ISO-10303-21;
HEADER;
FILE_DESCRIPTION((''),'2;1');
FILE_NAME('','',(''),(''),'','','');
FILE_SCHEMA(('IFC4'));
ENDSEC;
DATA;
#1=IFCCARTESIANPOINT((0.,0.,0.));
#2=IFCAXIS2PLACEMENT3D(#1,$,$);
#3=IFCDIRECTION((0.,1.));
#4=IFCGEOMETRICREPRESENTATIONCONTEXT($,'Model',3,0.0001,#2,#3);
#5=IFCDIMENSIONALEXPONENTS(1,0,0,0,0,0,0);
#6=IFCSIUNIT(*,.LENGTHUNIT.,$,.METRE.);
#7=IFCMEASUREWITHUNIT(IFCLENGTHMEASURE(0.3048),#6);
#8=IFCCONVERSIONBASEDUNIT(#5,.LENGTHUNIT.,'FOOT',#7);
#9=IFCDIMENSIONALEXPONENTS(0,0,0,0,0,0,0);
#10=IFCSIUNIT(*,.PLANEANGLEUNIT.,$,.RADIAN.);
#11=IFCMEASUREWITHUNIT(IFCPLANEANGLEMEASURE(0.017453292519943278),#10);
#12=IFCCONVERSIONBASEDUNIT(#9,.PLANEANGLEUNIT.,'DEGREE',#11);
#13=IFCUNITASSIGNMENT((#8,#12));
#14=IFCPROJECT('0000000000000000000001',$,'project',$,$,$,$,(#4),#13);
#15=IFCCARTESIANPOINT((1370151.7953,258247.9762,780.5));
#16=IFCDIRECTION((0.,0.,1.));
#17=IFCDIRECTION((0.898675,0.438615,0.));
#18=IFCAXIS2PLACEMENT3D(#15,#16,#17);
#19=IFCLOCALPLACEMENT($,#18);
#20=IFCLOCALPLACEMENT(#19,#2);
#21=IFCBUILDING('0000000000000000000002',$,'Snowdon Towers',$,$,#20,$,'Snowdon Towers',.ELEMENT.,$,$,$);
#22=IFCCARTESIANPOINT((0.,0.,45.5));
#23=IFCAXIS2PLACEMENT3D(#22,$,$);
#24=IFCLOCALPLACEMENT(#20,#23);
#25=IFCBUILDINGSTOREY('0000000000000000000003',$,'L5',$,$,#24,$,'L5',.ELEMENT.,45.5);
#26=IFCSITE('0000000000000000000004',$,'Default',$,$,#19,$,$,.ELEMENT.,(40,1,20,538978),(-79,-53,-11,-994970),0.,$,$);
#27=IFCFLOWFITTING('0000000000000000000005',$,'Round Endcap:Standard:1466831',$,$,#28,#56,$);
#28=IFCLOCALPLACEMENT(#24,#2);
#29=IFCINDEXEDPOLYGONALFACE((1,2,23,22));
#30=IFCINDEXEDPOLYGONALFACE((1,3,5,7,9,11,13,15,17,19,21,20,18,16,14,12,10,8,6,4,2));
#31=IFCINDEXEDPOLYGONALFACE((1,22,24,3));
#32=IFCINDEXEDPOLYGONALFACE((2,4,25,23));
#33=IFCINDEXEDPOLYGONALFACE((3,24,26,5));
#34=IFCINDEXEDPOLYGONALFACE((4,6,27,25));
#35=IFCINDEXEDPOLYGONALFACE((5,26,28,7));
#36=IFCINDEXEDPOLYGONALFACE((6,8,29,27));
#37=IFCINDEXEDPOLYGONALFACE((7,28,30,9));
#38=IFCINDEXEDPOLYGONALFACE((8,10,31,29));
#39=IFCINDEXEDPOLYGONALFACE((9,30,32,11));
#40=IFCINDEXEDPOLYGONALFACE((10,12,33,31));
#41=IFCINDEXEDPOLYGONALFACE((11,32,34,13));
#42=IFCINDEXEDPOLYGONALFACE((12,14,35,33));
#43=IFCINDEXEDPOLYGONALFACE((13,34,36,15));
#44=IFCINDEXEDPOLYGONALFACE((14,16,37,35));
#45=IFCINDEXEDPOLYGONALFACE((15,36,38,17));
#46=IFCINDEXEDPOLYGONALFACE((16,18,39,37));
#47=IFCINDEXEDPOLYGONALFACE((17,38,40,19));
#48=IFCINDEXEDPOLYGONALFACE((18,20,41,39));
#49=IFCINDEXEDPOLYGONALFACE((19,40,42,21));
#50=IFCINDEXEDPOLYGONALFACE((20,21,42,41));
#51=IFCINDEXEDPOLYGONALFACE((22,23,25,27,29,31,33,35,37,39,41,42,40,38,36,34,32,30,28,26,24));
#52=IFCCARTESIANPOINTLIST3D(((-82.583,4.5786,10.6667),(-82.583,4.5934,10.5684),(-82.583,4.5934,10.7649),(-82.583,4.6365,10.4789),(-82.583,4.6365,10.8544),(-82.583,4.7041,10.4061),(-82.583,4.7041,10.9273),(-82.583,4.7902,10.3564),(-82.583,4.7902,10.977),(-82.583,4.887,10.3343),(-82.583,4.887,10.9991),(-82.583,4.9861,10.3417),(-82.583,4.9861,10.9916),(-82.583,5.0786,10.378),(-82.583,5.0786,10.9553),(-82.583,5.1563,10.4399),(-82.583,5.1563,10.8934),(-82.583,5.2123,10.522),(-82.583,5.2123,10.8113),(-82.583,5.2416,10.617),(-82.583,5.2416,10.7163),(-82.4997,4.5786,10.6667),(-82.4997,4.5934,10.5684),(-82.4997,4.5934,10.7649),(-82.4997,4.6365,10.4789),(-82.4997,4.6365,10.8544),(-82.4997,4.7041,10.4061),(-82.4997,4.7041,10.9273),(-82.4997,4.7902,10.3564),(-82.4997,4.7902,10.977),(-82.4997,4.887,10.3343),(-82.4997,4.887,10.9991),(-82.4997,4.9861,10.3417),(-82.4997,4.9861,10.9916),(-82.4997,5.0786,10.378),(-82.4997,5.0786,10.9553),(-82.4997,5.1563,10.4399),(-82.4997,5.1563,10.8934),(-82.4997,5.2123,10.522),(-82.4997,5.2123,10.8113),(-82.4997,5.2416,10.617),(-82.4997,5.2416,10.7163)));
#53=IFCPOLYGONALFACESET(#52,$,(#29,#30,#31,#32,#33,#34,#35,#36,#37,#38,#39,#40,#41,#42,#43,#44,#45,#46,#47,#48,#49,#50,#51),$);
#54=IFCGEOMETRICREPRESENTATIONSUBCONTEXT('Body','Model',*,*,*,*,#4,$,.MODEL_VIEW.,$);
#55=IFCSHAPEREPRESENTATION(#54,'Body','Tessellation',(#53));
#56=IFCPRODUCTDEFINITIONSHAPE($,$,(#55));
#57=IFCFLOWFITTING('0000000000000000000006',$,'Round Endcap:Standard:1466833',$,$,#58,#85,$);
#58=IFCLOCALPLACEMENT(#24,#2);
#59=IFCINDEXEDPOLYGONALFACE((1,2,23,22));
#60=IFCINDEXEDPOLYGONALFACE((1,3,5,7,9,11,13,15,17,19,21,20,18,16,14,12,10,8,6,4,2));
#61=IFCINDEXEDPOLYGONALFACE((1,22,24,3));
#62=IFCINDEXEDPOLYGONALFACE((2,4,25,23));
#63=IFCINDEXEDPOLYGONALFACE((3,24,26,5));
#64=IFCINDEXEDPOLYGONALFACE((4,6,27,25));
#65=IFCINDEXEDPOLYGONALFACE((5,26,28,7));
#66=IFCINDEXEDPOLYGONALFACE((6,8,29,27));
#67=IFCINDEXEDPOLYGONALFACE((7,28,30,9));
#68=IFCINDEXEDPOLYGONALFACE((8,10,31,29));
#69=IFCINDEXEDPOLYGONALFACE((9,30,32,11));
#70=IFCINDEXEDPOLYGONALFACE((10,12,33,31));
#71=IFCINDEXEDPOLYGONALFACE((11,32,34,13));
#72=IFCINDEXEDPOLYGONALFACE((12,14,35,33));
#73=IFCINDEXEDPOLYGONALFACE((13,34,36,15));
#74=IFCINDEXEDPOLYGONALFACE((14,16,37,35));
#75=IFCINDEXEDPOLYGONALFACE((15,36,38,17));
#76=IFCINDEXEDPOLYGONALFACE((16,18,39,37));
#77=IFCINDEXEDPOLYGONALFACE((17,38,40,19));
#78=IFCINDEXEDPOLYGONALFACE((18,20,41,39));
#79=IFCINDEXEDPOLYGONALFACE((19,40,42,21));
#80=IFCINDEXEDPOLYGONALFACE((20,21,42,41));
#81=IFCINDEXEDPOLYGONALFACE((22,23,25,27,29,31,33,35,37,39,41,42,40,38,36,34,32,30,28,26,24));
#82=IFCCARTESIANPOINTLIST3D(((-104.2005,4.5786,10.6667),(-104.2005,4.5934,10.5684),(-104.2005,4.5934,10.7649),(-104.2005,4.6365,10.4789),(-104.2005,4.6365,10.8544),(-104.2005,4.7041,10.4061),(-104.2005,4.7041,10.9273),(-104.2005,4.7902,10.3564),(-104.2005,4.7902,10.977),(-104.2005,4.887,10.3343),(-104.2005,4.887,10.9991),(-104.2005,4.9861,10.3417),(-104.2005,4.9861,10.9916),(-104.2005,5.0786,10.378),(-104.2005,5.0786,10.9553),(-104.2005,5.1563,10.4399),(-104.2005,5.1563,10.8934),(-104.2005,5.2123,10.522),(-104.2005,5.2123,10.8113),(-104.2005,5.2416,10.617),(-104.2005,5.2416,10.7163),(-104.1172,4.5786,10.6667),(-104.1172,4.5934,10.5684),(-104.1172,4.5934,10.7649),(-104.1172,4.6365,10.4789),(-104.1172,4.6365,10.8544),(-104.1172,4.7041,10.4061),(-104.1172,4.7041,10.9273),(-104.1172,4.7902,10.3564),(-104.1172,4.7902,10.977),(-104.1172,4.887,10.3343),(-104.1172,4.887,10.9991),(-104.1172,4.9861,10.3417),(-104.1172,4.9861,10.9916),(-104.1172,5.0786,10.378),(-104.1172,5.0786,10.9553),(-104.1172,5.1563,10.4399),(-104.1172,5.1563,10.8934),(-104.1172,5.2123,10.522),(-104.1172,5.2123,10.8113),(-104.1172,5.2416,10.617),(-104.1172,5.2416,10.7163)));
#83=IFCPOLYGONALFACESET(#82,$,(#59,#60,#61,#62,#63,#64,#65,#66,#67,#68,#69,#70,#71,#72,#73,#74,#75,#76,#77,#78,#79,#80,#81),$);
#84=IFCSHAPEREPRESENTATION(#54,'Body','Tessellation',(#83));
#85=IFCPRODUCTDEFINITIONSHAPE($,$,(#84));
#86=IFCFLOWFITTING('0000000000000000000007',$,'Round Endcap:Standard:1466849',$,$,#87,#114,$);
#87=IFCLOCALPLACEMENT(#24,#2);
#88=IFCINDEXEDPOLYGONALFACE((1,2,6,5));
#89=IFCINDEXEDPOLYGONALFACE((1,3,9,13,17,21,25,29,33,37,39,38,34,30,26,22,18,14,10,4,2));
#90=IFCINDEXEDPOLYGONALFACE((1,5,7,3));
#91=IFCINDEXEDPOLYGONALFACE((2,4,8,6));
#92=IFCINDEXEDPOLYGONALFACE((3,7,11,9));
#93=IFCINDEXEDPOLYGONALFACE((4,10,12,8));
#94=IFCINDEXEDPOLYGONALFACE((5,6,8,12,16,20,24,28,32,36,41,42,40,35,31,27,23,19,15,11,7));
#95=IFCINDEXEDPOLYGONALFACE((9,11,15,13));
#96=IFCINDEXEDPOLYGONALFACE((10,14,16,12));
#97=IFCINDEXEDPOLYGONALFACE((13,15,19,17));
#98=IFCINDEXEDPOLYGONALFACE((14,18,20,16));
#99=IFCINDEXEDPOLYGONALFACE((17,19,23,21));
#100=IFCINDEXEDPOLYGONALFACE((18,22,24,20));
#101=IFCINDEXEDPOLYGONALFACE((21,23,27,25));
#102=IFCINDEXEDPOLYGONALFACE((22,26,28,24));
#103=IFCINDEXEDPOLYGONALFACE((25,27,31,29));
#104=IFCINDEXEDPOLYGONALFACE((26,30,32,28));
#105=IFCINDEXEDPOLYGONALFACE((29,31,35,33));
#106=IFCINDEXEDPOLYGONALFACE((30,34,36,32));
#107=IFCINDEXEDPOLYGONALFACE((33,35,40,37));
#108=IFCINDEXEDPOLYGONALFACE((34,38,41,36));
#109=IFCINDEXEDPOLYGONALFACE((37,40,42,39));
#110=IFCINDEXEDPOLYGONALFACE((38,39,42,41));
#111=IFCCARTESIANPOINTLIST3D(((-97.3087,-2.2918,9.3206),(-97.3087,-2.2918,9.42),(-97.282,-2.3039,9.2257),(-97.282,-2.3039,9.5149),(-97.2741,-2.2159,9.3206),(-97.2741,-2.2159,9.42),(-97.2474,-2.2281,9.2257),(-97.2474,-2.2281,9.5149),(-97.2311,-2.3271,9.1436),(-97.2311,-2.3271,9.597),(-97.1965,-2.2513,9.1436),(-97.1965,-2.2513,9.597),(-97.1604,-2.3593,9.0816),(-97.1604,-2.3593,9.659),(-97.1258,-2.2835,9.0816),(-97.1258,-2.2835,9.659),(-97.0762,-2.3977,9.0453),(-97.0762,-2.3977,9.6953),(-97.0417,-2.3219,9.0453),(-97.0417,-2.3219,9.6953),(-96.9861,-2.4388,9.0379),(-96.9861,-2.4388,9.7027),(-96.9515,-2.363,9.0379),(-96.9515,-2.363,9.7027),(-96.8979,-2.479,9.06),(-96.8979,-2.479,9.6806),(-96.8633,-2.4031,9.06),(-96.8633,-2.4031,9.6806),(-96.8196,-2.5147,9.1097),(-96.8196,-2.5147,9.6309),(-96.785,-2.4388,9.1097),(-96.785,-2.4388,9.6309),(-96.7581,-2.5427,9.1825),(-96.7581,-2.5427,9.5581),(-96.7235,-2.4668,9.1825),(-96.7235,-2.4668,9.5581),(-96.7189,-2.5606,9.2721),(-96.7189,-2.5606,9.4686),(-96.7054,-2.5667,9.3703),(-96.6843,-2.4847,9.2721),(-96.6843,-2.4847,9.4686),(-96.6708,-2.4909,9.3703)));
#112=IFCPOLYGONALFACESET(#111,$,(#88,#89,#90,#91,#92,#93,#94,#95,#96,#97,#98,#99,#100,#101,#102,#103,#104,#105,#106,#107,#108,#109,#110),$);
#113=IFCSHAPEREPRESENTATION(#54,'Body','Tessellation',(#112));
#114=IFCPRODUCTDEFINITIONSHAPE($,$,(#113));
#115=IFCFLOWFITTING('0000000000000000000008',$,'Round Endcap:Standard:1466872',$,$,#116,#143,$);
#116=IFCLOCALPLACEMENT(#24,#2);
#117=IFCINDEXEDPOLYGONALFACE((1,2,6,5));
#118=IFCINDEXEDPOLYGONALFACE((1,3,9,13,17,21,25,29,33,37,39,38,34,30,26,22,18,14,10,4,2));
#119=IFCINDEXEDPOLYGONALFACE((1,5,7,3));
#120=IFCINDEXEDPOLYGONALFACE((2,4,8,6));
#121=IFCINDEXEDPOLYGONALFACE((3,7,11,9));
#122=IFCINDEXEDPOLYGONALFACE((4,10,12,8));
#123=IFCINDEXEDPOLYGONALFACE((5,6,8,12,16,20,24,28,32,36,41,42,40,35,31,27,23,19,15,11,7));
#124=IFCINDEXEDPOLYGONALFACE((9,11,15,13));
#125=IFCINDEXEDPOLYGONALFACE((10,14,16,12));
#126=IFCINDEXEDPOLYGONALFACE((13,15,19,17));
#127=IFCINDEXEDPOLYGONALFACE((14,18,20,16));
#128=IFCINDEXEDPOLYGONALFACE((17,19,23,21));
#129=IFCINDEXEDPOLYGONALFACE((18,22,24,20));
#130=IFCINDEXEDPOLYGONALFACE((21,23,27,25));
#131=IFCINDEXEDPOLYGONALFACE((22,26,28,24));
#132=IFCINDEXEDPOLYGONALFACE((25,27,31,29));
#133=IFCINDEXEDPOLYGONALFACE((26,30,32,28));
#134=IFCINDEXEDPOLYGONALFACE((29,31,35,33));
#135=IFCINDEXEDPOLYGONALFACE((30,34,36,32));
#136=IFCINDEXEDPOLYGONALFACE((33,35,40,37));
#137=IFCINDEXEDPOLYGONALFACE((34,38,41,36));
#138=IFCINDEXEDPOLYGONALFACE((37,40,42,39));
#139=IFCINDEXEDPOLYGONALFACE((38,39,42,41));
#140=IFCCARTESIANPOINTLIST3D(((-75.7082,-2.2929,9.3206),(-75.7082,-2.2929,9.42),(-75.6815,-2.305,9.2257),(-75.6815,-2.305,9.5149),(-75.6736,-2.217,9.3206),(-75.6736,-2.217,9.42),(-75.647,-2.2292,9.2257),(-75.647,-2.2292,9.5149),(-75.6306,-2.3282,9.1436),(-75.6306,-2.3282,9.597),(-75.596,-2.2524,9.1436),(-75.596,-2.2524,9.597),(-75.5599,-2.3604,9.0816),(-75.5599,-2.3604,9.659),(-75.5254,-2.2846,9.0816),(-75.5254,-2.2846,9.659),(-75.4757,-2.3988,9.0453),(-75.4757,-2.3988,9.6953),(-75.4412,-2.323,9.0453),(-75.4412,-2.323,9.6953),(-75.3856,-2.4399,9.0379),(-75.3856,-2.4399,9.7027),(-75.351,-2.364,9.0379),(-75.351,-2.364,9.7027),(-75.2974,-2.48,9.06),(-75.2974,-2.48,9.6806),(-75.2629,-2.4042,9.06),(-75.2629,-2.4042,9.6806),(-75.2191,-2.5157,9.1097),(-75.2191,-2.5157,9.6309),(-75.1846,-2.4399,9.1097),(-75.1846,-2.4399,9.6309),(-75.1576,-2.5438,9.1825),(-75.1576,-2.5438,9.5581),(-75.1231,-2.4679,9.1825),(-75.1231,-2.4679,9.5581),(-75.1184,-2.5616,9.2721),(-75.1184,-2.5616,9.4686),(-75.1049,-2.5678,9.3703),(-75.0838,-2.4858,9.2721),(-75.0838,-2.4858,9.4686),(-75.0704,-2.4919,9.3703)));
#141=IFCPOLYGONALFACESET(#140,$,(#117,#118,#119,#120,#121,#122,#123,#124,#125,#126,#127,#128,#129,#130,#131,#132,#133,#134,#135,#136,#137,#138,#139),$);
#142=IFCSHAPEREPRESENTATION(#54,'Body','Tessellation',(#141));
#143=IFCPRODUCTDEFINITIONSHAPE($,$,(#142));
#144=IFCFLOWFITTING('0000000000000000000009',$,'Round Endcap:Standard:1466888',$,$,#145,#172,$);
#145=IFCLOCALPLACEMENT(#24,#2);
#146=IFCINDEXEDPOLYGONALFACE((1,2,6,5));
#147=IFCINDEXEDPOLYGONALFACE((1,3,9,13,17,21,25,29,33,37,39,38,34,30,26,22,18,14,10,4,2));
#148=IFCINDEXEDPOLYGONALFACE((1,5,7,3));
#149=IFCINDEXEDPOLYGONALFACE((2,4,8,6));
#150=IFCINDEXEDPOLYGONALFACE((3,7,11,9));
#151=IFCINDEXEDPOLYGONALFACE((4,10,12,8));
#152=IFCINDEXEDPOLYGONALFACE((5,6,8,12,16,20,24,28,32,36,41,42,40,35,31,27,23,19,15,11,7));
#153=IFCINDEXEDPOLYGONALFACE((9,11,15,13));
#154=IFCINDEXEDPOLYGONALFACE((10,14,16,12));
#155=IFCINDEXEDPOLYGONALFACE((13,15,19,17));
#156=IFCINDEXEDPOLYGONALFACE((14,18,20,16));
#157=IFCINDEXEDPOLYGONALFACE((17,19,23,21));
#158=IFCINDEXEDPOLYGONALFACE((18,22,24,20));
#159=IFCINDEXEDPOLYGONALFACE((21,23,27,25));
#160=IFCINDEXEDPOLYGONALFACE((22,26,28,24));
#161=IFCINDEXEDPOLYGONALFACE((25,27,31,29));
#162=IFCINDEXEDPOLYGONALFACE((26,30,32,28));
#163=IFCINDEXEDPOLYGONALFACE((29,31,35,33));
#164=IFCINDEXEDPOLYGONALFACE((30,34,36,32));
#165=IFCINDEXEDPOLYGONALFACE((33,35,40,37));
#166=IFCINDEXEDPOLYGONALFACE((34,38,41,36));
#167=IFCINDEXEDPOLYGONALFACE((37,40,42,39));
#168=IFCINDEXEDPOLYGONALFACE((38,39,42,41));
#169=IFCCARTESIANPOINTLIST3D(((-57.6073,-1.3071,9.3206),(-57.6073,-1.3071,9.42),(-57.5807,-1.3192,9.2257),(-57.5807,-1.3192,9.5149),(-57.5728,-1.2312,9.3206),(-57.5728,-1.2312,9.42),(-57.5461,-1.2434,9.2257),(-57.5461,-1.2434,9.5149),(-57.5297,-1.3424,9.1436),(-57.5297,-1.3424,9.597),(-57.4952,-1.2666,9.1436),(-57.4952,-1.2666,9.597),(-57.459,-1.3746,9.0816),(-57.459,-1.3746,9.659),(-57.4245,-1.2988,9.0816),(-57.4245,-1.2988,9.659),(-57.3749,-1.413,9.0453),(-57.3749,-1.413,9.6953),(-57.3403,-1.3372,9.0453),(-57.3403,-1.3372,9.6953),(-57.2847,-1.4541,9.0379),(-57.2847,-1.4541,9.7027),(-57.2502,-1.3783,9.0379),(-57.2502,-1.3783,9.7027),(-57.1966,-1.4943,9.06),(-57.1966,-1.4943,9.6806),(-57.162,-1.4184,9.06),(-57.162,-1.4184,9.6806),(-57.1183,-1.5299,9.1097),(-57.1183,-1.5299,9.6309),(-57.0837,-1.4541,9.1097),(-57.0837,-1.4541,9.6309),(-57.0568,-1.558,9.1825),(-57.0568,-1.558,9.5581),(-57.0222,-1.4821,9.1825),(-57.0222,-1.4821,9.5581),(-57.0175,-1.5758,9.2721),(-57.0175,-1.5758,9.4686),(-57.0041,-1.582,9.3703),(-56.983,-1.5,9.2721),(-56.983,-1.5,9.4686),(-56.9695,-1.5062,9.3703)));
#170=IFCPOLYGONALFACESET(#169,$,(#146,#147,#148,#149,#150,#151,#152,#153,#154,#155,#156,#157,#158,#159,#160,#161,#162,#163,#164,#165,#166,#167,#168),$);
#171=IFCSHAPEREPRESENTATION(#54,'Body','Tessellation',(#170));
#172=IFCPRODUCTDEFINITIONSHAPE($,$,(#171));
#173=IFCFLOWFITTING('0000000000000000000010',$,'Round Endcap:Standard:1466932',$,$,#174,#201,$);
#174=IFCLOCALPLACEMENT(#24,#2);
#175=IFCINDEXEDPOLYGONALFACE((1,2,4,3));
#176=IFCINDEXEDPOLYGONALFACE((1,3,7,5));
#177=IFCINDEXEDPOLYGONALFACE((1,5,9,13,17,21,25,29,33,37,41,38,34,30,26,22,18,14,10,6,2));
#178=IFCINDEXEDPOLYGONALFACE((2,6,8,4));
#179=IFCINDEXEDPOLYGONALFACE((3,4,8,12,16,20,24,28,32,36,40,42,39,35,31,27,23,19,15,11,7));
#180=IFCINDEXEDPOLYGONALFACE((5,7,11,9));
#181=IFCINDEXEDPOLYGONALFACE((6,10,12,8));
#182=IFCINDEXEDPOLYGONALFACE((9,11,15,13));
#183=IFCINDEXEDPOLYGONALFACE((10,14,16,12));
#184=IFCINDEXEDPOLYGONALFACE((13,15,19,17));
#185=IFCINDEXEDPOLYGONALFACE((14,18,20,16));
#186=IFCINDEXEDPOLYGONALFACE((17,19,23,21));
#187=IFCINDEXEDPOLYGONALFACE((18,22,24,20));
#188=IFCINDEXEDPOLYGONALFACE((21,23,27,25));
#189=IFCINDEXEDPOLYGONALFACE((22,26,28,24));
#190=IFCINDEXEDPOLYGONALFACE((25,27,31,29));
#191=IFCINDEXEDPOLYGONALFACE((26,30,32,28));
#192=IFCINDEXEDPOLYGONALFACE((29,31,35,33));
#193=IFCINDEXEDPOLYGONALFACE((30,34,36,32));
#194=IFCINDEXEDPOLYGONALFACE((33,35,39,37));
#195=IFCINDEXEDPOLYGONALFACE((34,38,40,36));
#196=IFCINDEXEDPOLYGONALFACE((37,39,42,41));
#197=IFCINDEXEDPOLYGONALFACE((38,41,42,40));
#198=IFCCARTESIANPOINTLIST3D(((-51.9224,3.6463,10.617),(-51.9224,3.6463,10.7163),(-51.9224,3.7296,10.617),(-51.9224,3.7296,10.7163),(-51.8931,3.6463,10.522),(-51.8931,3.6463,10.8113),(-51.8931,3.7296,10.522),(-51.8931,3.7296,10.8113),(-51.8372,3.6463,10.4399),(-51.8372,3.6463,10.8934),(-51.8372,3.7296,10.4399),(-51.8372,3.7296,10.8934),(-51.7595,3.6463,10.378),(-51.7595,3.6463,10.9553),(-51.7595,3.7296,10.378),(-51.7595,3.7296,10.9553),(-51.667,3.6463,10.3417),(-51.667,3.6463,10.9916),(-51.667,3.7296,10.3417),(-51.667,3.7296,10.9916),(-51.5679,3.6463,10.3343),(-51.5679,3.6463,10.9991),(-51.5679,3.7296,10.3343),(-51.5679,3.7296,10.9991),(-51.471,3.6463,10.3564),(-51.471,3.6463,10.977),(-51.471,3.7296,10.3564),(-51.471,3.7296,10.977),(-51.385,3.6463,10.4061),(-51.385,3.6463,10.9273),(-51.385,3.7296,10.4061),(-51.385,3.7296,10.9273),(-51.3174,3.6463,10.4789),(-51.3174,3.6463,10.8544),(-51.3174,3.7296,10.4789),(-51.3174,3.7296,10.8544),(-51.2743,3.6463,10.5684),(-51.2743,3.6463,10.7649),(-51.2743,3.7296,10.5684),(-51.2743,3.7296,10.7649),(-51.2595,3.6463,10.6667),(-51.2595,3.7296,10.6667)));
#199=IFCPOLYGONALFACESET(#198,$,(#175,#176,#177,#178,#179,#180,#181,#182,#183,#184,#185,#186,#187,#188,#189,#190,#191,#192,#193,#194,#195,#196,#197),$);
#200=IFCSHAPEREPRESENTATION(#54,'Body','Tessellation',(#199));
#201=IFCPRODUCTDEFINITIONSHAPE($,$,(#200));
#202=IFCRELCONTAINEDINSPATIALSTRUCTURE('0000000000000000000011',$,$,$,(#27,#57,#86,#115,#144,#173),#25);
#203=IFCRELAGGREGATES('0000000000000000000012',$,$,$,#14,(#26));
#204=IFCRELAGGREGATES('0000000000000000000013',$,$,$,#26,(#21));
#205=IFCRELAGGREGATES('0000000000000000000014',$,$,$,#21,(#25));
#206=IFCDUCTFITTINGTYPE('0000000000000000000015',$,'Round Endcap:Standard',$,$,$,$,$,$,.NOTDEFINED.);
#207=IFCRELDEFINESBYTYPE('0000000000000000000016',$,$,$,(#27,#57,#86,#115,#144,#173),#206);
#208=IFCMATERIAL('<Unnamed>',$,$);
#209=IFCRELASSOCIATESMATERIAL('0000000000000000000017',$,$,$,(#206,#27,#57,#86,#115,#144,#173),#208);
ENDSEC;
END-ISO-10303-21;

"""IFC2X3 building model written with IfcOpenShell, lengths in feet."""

from ifc_helpers import new_model, entity, si_unit, converted_unit, direction, frame, frame_2d, origin, place, context, subcontext, project, spatial, circle, extrude, source, transform, mapped, material, type_object, type_shapes, element, save


model = new_model("IFC2X3")

# Units and contexts
model_context = context("Model", 3, precision=0.0001, world=origin(), true_north=direction((0.0, 1.0)))
body_context = subcontext(model_context, "Body", "Model", "MODEL_VIEW")
ifc_project = project(units=[converted_unit("LENGTHUNIT", "FOOT", entity("IfcLengthMeasure", 0.3048), si_unit("LENGTHUNIT", "METRE"), dimensions=[1, 0, 0, 0, 0, 0, 0]), converted_unit("PLANEANGLEUNIT", "DEGREE", entity("IfcPlaneAngleMeasure", 0.017453292519943278), si_unit("PLANEANGLEUNIT", "RADIAN"), dimensions=[0, 0, 0, 0, 0, 0, 0])], contexts=[model_context])

# Site, building, storey
site_placement = place(None, frame((1370151.7953, 258247.9762, 780.5), z_axis=(0.0, 0.0, 1.0), x_axis=(0.898675, 0.438615, 0.0)))
site = spatial("IfcSite", under=ifc_project, at=site_placement, Name="Default", CompositionType="ELEMENT", RefLatitude=(40, 1, 20, 538978), RefLongitude=(-79, -53, -11, -994970), RefElevation=0.0)
building_placement = place(site_placement, origin())
building = spatial("IfcBuilding", under=site, at=building_placement, Name="Snowdon Towers", LongName="Snowdon Towers", CompositionType="ELEMENT")
storey_placement = place(building_placement, frame((0.0, 0.0, 45.5)))
storey = spatial("IfcBuildingStorey", under=building, at=storey_placement, Name="L5", LongName="L5", CompositionType="ELEMENT", Elevation=45.5)

# Flow fittings
ifc_material = material(Name="<Unnamed>")
duct_fitting_type = type_object("IfcDuctFittingType", Name="Round Endcap:Standard", PredefinedType="NOTDEFINED", material=ifc_material)
shared_shape_1 = source(origin(), body_context, "Body", "SweptSolid", [
    extrude(circle(Radius=0.3333, at=frame_2d((0.0, 0.0), x_axis=(1.0, 0.0))), frame((0.0, 0.0, 0.0), z_axis=(1.0, 0.0, 0.0), x_axis=(0.0, 1.0, 0.0)), (0.0, 0.0, 1.0), 0.0833),
])
type_shapes(duct_fitting_type, [shared_shape_1])
for number, where, z_axis, x_axis, name in (
    (1, (-82.4997, 4.912, 10.6667), (0.0, 0.0, 1.0), (-1.0, 0.0, 0.0), "Round Endcap:Standard:1466831"),
    (2, (-104.1172, 4.912, 10.6667), (0.0, 0.0, 1.0), (-1.0, 0.0, 0.0), "Round Endcap:Standard:1466833"),
    (3, (-96.9742, -2.3526, 9.3703), (0.0, 0.0, 1.0), (-0.414693, -0.909961, 0.0), "Round Endcap:Standard:1466849"),
    (4, (-75.3737, -2.3537, 9.3703), (0.0, 0.0, 1.0), (-0.414693, -0.909961, 0.0), "Round Endcap:Standard:1466872"),
    (5, (-57.2728, -1.3679, 9.3703), (0.0, 0.0, 1.0), (-0.414693, -0.909961, 0.0), "Round Endcap:Standard:1466888"),
    (6, (-51.5928, 3.7296, 10.6667), (0.0, 0.0, 1.0), (0.0, -1.0, 0.0), "Round Endcap:Standard:1466932"),
):
    element("IfcFlowFitting", number, at=place(storey_placement, frame(where, z_axis=z_axis, x_axis=x_axis)), inside=storey, type_object=duct_fitting_type, material=ifc_material, Name=name, context=body_context, shape_type="MappedRepresentation", body=[
        mapped(shared_shape_1, transform((0.0, 0.0, 0.0), scale=1.0)),
    ])

save(model, "model.ifc")
